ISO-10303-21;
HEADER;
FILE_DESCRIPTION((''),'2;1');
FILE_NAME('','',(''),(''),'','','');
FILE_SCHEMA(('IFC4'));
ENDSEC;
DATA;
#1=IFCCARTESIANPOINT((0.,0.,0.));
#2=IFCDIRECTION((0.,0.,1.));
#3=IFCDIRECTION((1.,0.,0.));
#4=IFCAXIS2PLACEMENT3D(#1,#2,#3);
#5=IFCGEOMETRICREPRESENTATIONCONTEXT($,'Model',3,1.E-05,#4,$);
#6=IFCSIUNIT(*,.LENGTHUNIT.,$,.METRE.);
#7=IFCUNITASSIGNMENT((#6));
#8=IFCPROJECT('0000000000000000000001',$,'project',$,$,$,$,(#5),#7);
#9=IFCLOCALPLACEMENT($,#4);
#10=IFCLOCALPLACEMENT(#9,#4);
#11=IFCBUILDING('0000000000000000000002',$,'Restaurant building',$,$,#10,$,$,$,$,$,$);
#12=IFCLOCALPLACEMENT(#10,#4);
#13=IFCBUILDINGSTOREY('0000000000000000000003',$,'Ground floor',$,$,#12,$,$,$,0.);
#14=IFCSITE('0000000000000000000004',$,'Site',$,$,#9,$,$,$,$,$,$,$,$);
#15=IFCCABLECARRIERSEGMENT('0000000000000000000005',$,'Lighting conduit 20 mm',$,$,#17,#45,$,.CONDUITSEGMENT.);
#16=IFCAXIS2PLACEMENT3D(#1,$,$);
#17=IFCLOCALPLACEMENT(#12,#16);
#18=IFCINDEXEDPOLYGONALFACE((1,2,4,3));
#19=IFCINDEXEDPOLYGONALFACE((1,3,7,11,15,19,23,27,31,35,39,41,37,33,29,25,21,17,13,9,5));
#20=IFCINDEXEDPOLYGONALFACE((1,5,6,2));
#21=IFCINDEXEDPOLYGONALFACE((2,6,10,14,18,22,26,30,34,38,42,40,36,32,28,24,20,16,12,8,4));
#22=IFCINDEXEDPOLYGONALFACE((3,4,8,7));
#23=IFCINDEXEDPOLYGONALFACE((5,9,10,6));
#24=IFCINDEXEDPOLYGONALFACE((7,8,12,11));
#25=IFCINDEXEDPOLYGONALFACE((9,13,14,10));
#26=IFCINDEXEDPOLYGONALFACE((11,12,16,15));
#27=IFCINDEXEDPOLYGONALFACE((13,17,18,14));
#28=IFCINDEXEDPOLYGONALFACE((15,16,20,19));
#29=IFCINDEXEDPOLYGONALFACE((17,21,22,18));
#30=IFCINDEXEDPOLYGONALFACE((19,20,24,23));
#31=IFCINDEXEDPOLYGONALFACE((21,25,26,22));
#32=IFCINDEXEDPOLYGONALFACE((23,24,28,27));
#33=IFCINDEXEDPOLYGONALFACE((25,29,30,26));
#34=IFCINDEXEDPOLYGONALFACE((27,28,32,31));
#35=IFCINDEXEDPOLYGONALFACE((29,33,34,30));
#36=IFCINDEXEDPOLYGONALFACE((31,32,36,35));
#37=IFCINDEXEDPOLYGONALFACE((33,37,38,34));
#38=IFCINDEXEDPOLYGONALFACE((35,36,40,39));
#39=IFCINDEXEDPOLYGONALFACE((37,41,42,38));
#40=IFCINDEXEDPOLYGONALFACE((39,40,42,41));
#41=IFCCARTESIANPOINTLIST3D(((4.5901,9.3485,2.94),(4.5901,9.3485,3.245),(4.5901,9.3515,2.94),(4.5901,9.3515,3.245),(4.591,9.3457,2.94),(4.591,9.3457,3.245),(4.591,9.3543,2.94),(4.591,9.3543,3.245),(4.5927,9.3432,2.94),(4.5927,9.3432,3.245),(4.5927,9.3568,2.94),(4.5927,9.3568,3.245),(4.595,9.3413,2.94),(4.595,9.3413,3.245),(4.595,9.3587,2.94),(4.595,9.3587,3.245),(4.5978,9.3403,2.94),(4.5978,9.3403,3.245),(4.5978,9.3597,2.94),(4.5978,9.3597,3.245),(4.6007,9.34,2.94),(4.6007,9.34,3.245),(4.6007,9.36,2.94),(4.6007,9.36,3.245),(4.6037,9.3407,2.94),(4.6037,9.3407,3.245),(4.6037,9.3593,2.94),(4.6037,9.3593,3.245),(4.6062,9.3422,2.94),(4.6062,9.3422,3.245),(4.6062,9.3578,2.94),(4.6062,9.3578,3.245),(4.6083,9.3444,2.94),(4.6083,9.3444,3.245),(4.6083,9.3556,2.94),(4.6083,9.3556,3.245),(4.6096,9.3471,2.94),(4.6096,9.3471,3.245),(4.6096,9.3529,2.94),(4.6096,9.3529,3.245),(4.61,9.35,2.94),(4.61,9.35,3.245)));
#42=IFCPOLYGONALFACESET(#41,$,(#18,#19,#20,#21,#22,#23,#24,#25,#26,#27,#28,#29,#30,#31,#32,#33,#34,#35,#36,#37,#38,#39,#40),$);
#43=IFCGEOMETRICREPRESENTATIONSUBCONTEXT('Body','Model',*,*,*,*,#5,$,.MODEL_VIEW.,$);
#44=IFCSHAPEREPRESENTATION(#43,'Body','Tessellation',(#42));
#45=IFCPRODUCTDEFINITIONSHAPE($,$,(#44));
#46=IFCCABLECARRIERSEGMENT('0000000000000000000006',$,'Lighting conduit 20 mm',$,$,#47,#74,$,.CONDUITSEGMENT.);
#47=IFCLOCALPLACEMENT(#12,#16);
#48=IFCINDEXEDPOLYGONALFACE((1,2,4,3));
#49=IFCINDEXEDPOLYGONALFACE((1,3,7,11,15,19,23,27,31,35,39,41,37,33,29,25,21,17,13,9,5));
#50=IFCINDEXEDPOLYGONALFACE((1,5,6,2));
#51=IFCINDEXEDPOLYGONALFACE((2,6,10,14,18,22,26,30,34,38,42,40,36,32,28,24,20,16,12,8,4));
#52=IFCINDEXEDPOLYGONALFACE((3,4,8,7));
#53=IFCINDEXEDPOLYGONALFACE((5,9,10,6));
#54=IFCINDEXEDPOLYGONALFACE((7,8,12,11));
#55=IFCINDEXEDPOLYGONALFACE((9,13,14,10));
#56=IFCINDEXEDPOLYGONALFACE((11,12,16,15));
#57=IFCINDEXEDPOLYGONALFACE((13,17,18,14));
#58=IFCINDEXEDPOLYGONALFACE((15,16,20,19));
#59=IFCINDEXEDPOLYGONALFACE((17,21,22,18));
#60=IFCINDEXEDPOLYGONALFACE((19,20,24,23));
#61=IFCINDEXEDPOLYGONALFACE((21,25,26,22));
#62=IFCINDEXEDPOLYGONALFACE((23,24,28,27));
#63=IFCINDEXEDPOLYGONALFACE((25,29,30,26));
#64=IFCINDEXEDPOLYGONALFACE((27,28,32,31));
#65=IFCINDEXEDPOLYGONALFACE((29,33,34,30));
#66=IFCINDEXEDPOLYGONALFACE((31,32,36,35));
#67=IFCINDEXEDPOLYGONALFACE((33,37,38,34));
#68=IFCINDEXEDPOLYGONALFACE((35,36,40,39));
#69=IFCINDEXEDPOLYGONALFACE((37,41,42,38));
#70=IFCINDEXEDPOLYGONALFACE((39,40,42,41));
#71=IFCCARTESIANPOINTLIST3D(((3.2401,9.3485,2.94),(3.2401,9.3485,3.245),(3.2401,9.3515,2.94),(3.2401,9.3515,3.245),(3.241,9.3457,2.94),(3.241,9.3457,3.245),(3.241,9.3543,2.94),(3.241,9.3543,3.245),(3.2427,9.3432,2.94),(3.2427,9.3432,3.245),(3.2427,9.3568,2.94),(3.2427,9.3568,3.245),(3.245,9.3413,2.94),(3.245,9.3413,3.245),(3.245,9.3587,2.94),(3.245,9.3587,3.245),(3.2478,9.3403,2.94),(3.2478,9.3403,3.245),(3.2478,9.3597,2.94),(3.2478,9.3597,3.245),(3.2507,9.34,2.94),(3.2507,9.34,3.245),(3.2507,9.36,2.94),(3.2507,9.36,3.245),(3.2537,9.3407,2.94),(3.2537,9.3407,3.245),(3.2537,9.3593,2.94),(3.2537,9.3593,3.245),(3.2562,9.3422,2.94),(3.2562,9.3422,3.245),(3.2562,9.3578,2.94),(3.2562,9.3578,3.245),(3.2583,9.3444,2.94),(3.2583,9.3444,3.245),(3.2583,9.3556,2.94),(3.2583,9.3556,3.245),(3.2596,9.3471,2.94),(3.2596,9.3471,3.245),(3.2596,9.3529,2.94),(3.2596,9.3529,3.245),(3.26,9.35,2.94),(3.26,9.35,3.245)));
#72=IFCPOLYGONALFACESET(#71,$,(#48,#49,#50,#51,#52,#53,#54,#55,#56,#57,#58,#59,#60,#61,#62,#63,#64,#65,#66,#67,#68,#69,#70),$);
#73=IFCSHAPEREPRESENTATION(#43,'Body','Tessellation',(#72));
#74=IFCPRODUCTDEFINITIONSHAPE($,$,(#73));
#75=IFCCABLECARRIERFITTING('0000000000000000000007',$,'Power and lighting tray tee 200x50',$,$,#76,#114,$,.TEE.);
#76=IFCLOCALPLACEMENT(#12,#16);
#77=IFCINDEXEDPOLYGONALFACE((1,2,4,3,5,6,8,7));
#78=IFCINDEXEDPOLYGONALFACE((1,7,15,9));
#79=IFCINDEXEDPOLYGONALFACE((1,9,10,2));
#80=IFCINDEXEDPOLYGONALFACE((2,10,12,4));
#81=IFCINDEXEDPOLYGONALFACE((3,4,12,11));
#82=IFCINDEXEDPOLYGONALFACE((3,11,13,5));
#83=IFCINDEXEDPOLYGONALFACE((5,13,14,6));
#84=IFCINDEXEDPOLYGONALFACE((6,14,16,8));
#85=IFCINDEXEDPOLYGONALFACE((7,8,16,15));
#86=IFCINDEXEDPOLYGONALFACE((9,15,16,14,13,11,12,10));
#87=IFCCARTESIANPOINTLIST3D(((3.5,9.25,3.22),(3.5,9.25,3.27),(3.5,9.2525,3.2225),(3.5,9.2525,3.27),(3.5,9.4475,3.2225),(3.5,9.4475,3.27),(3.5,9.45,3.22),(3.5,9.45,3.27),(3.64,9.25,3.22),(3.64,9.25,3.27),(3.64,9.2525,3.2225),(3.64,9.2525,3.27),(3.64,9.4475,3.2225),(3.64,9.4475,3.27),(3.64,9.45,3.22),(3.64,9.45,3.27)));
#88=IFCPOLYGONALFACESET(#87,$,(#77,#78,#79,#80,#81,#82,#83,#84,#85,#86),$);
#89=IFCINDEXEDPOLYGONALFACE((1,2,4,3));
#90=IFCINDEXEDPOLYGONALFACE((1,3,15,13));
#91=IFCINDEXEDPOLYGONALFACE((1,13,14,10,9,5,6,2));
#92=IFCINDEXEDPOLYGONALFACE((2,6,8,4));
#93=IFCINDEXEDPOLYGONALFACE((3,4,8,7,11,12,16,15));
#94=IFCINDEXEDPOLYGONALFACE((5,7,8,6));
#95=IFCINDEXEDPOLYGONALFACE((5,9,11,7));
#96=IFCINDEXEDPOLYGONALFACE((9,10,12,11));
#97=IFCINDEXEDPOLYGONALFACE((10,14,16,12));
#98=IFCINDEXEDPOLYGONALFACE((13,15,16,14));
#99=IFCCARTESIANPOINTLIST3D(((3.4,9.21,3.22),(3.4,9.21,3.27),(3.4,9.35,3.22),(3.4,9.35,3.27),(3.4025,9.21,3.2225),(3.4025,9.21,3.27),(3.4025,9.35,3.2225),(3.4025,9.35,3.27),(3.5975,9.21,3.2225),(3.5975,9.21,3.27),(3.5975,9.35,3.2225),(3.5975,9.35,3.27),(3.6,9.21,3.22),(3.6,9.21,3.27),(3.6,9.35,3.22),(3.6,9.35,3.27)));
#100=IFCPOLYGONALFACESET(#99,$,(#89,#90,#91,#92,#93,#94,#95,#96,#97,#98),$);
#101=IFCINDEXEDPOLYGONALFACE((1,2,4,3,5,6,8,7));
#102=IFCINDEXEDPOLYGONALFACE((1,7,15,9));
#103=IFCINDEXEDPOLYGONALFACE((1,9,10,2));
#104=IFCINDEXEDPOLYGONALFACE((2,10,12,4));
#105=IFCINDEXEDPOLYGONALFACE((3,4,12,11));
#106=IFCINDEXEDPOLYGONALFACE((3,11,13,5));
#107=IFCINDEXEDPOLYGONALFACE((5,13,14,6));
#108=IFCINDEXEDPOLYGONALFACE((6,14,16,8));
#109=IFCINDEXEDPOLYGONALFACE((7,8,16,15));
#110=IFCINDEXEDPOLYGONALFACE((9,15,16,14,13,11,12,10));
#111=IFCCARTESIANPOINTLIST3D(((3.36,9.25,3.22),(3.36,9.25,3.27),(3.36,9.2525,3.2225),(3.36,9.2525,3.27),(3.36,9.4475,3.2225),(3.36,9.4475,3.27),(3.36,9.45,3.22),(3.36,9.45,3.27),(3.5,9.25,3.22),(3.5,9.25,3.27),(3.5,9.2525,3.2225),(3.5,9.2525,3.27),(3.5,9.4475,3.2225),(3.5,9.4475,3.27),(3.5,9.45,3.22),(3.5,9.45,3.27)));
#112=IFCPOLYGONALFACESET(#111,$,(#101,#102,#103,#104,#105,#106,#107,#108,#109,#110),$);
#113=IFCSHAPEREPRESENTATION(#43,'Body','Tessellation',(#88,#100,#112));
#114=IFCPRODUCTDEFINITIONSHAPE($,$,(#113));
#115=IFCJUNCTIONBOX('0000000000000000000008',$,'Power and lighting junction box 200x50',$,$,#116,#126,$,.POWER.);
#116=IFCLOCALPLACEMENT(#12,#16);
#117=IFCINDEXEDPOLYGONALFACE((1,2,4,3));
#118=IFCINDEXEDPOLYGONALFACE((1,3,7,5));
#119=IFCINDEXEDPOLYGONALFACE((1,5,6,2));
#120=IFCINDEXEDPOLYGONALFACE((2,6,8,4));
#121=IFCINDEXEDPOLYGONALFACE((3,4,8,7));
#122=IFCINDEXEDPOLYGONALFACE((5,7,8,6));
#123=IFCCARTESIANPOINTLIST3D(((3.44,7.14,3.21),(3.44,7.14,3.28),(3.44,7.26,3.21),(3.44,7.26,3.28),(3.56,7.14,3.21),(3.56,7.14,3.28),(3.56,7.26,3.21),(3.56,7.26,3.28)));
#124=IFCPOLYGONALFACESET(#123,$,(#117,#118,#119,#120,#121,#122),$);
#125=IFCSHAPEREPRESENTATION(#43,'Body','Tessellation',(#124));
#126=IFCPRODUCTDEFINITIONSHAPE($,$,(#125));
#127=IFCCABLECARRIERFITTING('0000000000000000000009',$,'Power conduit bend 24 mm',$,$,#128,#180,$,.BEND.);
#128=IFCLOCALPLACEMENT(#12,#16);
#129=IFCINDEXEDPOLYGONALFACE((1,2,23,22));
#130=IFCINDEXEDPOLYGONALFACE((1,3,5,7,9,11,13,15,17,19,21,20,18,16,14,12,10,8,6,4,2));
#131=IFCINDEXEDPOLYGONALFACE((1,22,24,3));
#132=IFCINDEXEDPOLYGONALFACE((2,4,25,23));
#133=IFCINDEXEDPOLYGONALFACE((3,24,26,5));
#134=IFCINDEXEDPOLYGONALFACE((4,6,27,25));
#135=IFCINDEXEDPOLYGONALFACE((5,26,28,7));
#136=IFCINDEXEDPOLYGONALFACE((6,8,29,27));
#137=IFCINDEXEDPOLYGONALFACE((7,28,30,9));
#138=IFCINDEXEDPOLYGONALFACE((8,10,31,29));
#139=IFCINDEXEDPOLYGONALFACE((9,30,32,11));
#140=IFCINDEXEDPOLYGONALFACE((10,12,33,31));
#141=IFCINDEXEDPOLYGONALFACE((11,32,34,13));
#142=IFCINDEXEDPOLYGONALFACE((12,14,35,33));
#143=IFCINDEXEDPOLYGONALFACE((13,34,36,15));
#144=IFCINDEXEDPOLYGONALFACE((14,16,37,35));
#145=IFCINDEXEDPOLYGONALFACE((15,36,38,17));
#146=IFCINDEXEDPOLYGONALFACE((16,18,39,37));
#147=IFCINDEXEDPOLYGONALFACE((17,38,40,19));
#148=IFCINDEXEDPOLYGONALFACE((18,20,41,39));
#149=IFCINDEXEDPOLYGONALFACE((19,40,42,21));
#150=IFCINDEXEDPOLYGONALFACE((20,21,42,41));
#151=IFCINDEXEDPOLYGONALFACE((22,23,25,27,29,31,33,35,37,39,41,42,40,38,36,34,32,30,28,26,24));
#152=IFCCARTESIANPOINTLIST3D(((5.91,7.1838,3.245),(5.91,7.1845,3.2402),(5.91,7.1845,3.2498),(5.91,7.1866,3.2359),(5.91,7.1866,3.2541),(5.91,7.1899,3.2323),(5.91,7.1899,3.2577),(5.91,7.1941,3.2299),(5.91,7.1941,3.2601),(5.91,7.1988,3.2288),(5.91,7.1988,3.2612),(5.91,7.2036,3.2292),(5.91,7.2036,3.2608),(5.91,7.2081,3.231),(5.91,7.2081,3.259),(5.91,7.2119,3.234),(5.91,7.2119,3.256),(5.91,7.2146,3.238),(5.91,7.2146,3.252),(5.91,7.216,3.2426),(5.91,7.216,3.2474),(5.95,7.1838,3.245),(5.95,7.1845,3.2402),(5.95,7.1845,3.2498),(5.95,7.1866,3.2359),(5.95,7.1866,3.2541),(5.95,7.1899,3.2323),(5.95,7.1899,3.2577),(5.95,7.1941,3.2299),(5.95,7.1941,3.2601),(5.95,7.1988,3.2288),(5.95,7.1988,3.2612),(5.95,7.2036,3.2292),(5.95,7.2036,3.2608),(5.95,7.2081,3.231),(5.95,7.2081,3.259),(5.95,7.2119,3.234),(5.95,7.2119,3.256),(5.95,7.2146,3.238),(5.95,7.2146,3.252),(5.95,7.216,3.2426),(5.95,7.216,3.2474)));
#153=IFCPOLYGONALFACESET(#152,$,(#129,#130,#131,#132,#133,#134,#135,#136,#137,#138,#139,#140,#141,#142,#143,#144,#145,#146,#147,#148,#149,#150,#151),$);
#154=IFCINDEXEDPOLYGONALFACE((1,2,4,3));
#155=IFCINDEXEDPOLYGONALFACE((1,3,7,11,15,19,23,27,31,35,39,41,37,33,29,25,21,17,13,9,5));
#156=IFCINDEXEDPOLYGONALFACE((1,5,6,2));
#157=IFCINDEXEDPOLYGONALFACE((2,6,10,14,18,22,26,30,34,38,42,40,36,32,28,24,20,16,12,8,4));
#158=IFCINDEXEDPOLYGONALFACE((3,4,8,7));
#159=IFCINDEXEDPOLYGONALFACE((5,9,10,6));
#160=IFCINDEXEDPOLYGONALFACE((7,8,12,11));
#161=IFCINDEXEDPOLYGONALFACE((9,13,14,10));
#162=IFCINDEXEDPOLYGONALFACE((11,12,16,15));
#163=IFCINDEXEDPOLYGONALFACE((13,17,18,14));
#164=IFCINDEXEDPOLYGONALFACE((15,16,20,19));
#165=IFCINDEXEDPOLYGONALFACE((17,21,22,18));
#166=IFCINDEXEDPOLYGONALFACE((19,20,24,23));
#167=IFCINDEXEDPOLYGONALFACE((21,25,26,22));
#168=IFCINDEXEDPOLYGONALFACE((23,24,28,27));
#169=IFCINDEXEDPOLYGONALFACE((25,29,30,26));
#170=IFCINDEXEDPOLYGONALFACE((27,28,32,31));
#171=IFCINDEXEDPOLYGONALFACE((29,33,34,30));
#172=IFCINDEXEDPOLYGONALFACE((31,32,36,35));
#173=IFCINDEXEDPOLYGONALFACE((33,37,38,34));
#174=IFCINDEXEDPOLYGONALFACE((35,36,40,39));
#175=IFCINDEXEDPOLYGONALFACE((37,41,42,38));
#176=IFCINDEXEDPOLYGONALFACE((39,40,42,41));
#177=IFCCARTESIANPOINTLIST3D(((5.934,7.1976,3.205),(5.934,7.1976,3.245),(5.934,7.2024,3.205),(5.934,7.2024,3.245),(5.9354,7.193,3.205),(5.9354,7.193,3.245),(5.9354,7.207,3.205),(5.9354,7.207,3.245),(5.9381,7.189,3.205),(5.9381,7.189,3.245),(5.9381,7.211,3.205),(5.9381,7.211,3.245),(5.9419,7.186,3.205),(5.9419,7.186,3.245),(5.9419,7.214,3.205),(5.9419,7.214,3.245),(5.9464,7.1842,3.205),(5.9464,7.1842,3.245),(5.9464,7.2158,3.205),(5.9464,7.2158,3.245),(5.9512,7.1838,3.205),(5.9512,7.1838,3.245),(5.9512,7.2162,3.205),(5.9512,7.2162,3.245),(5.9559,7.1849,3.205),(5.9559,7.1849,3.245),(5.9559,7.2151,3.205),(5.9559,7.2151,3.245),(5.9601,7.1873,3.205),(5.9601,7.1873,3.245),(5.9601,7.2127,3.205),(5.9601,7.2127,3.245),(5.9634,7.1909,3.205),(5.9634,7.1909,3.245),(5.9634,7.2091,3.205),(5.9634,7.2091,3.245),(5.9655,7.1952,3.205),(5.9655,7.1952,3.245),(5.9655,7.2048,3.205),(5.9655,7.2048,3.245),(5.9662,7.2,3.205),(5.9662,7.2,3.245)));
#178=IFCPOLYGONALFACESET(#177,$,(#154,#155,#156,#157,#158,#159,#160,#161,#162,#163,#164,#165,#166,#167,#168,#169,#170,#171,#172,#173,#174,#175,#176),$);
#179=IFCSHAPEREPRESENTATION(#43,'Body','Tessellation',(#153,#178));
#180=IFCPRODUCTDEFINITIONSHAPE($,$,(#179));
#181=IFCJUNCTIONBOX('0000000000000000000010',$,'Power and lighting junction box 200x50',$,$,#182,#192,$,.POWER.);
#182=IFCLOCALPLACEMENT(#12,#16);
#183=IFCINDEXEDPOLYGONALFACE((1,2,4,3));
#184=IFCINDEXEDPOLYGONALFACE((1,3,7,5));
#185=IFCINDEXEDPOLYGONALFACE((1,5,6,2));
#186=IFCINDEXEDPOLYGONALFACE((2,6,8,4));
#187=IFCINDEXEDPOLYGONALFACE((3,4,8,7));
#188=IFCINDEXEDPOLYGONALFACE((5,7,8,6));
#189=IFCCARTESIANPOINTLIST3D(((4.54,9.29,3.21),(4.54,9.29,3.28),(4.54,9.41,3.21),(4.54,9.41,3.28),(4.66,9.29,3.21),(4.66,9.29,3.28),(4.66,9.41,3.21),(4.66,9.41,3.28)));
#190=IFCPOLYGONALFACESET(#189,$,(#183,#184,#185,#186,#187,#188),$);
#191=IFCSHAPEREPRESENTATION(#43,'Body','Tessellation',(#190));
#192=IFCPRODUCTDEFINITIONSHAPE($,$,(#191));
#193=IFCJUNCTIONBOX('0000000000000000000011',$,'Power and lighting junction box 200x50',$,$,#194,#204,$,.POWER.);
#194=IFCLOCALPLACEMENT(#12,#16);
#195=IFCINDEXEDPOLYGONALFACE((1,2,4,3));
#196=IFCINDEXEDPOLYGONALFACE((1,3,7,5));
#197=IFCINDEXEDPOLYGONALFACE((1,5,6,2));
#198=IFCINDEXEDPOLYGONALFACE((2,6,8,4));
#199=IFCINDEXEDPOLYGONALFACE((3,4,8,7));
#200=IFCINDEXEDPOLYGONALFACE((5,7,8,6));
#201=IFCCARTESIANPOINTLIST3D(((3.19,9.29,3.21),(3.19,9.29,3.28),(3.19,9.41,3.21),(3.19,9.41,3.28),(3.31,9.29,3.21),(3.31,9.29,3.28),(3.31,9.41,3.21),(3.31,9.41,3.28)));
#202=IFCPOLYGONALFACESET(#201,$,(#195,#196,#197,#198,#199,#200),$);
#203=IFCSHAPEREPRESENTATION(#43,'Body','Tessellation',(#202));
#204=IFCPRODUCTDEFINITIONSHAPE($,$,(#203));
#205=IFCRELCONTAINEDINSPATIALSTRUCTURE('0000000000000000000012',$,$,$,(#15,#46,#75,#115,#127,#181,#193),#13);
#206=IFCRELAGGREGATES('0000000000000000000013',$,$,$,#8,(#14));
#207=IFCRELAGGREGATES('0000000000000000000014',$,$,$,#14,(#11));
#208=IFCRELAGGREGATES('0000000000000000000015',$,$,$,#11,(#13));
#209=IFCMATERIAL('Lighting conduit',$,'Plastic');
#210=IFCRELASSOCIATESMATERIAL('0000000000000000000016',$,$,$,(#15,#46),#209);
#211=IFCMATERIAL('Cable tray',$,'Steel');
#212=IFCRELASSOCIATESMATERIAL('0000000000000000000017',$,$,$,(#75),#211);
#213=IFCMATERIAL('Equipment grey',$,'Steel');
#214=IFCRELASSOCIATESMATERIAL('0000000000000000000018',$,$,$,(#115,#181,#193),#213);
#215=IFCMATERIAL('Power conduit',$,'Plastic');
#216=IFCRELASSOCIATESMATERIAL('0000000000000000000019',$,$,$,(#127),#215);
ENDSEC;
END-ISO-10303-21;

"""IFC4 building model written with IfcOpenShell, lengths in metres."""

from ifc_helpers import new_model, si_unit, frame, origin_with_axes, origin_2d, place, context, subcontext, project, spatial, polyline, rectangle, circle, outline, extrude, material, element, save


model = new_model("IFC4")

# Units and contexts
model_context = context("Model", 3, precision=1e-05, world=origin_with_axes())
body_context = subcontext(model_context, "Body", "Model", "MODEL_VIEW")
ifc_project = project(units=[si_unit("LENGTHUNIT", "METRE")], contexts=[model_context])

# Site, building, storey
site_placement = place(None, origin_with_axes())
site = spatial("IfcSite", under=ifc_project, at=site_placement, Name="Site")
building_placement = place(site_placement, origin_with_axes())
building = spatial("IfcBuilding", under=site, at=building_placement, Name="Restaurant building")
storey_placement = place(building_placement, origin_with_axes())
storey = spatial("IfcBuildingStorey", under=building, at=storey_placement, Name="Ground floor", Elevation=0.0)

# Cable carrier segments
ifc_material_1 = material(Name="Cable tray", Category="Steel")
ifc_material_2 = material(Name="Power conduit", Category="Plastic")
ifc_material_3 = material(Name="Lighting conduit", Category="Plastic")
for number, where, name in (
    (1, (4.6, 9.35, 3.245), "Lighting conduit 20 mm"),
    (2, (3.25, 9.35, 3.245), "Lighting conduit 20 mm"),
):
    element("IfcCableCarrierSegment", number, at=place(storey_placement, frame(where)), inside=storey, material=ifc_material_3, Name=name, PredefinedType="CONDUITSEGMENT", context=body_context, shape_type="SweptSolid", body=[
        extrude(circle(Radius=0.01, at=origin_2d()), frame((0.0, 0.0, 0.0), z_axis=(0.0, 0.0, -1.0), x_axis=(1.0, 0.0, 0.0)), (0.0, 0.0, 1.0), 0.305),
    ])

# Cable carrier fitting
cable_carrier_fitting_1_placement = place(storey_placement, frame((3.5, 9.35, 3.245)))
element("IfcCableCarrierFitting", 3, at=cable_carrier_fitting_1_placement, inside=storey, material=ifc_material_1, Name="Power and lighting tray tee 200x50", PredefinedType="TEE", context=body_context, shape_type="SweptSolid", body=[
    extrude(outline(polyline([(-0.1, -0.025), (0.1, -0.025), (0.1, 0.025), (0.0975, 0.025), (0.0975, -0.0225), (-0.0975, -0.0225), (-0.0975, 0.025), (-0.1, 0.025), (-0.1, -0.025)])), frame((0.0, 0.0, 0.0), z_axis=(1.0, 0.0, 0.0), x_axis=(0.0, 1.0, 0.0)), (0.0, 0.0, 1.0), 0.14),
    extrude(outline(polyline([(-0.1, -0.025), (0.1, -0.025), (0.1, 0.025), (0.0975, 0.025), (0.0975, -0.0225), (-0.0975, -0.0225), (-0.0975, 0.025), (-0.1, 0.025), (-0.1, -0.025)])), frame((0.0, 0.0, 0.0), z_axis=(0.0, -1.0, 0.0), x_axis=(1.0, 0.0, 0.0)), (0.0, 0.0, 1.0), 0.14),
    extrude(outline(polyline([(-0.1, -0.025), (0.1, -0.025), (0.1, 0.025), (0.0975, 0.025), (0.0975, -0.0225), (-0.0975, -0.0225), (-0.0975, 0.025), (-0.1, 0.025), (-0.1, -0.025)])), frame((0.0, 0.0, 0.0), z_axis=(-1.0, 0.0, 0.0), x_axis=(0.0, -1.0, 0.0)), (0.0, 0.0, 1.0), 0.14),
])

# Junction box
ifc_material_4 = material(Name="Equipment grey", Category="Steel")
junction_box_placement = place(storey_placement, frame((3.5, 7.2, 3.245)))
element("IfcJunctionBox", 4, at=junction_box_placement, inside=storey, material=ifc_material_4, Name="Power and lighting junction box 200x50", PredefinedType="POWER", context=body_context, shape_type="SweptSolid", body=[
    extrude(rectangle(XDim=0.12, YDim=0.12, at=origin_2d()), frame((0.0, 0.0, -0.035)), (0.0, 0.0, 1.0), 0.07),
])

# Cable carrier fitting
cable_carrier_fitting_2_placement = place(storey_placement, frame((5.95, 7.2, 3.245)))
element("IfcCableCarrierFitting", 5, at=cable_carrier_fitting_2_placement, inside=storey, material=ifc_material_2, Name="Power conduit bend 24 mm", PredefinedType="BEND", context=body_context, shape_type="SweptSolid", body=[
    extrude(circle(Radius=0.0162, at=origin_2d()), frame((0.0, 0.0, 0.0), z_axis=(-1.0, 0.0, 0.0), x_axis=(0.0, -1.0, 0.0)), (0.0, 0.0, 1.0), 0.04),
    extrude(circle(Radius=0.0162, at=origin_2d()), frame((0.0, 0.0, 0.0), z_axis=(0.0, 0.0, -1.0), x_axis=(1.0, 0.0, 0.0)), (0.0, 0.0, 1.0), 0.04),
])

# Junction boxes
for number, where, name in (
    (6, (4.6, 9.35, 3.245), "Power and lighting junction box 200x50"),
    (7, (3.25, 9.35, 3.245), "Power and lighting junction box 200x50"),
):
    element("IfcJunctionBox", number, at=place(storey_placement, frame(where)), inside=storey, material=ifc_material_4, Name=name, PredefinedType="POWER", context=body_context, shape_type="SweptSolid", body=[
        extrude(rectangle(XDim=0.12, YDim=0.12, at=origin_2d()), frame((0.0, 0.0, -0.035)), (0.0, 0.0, 1.0), 0.07),
    ])

save(model, "model.ifc")
